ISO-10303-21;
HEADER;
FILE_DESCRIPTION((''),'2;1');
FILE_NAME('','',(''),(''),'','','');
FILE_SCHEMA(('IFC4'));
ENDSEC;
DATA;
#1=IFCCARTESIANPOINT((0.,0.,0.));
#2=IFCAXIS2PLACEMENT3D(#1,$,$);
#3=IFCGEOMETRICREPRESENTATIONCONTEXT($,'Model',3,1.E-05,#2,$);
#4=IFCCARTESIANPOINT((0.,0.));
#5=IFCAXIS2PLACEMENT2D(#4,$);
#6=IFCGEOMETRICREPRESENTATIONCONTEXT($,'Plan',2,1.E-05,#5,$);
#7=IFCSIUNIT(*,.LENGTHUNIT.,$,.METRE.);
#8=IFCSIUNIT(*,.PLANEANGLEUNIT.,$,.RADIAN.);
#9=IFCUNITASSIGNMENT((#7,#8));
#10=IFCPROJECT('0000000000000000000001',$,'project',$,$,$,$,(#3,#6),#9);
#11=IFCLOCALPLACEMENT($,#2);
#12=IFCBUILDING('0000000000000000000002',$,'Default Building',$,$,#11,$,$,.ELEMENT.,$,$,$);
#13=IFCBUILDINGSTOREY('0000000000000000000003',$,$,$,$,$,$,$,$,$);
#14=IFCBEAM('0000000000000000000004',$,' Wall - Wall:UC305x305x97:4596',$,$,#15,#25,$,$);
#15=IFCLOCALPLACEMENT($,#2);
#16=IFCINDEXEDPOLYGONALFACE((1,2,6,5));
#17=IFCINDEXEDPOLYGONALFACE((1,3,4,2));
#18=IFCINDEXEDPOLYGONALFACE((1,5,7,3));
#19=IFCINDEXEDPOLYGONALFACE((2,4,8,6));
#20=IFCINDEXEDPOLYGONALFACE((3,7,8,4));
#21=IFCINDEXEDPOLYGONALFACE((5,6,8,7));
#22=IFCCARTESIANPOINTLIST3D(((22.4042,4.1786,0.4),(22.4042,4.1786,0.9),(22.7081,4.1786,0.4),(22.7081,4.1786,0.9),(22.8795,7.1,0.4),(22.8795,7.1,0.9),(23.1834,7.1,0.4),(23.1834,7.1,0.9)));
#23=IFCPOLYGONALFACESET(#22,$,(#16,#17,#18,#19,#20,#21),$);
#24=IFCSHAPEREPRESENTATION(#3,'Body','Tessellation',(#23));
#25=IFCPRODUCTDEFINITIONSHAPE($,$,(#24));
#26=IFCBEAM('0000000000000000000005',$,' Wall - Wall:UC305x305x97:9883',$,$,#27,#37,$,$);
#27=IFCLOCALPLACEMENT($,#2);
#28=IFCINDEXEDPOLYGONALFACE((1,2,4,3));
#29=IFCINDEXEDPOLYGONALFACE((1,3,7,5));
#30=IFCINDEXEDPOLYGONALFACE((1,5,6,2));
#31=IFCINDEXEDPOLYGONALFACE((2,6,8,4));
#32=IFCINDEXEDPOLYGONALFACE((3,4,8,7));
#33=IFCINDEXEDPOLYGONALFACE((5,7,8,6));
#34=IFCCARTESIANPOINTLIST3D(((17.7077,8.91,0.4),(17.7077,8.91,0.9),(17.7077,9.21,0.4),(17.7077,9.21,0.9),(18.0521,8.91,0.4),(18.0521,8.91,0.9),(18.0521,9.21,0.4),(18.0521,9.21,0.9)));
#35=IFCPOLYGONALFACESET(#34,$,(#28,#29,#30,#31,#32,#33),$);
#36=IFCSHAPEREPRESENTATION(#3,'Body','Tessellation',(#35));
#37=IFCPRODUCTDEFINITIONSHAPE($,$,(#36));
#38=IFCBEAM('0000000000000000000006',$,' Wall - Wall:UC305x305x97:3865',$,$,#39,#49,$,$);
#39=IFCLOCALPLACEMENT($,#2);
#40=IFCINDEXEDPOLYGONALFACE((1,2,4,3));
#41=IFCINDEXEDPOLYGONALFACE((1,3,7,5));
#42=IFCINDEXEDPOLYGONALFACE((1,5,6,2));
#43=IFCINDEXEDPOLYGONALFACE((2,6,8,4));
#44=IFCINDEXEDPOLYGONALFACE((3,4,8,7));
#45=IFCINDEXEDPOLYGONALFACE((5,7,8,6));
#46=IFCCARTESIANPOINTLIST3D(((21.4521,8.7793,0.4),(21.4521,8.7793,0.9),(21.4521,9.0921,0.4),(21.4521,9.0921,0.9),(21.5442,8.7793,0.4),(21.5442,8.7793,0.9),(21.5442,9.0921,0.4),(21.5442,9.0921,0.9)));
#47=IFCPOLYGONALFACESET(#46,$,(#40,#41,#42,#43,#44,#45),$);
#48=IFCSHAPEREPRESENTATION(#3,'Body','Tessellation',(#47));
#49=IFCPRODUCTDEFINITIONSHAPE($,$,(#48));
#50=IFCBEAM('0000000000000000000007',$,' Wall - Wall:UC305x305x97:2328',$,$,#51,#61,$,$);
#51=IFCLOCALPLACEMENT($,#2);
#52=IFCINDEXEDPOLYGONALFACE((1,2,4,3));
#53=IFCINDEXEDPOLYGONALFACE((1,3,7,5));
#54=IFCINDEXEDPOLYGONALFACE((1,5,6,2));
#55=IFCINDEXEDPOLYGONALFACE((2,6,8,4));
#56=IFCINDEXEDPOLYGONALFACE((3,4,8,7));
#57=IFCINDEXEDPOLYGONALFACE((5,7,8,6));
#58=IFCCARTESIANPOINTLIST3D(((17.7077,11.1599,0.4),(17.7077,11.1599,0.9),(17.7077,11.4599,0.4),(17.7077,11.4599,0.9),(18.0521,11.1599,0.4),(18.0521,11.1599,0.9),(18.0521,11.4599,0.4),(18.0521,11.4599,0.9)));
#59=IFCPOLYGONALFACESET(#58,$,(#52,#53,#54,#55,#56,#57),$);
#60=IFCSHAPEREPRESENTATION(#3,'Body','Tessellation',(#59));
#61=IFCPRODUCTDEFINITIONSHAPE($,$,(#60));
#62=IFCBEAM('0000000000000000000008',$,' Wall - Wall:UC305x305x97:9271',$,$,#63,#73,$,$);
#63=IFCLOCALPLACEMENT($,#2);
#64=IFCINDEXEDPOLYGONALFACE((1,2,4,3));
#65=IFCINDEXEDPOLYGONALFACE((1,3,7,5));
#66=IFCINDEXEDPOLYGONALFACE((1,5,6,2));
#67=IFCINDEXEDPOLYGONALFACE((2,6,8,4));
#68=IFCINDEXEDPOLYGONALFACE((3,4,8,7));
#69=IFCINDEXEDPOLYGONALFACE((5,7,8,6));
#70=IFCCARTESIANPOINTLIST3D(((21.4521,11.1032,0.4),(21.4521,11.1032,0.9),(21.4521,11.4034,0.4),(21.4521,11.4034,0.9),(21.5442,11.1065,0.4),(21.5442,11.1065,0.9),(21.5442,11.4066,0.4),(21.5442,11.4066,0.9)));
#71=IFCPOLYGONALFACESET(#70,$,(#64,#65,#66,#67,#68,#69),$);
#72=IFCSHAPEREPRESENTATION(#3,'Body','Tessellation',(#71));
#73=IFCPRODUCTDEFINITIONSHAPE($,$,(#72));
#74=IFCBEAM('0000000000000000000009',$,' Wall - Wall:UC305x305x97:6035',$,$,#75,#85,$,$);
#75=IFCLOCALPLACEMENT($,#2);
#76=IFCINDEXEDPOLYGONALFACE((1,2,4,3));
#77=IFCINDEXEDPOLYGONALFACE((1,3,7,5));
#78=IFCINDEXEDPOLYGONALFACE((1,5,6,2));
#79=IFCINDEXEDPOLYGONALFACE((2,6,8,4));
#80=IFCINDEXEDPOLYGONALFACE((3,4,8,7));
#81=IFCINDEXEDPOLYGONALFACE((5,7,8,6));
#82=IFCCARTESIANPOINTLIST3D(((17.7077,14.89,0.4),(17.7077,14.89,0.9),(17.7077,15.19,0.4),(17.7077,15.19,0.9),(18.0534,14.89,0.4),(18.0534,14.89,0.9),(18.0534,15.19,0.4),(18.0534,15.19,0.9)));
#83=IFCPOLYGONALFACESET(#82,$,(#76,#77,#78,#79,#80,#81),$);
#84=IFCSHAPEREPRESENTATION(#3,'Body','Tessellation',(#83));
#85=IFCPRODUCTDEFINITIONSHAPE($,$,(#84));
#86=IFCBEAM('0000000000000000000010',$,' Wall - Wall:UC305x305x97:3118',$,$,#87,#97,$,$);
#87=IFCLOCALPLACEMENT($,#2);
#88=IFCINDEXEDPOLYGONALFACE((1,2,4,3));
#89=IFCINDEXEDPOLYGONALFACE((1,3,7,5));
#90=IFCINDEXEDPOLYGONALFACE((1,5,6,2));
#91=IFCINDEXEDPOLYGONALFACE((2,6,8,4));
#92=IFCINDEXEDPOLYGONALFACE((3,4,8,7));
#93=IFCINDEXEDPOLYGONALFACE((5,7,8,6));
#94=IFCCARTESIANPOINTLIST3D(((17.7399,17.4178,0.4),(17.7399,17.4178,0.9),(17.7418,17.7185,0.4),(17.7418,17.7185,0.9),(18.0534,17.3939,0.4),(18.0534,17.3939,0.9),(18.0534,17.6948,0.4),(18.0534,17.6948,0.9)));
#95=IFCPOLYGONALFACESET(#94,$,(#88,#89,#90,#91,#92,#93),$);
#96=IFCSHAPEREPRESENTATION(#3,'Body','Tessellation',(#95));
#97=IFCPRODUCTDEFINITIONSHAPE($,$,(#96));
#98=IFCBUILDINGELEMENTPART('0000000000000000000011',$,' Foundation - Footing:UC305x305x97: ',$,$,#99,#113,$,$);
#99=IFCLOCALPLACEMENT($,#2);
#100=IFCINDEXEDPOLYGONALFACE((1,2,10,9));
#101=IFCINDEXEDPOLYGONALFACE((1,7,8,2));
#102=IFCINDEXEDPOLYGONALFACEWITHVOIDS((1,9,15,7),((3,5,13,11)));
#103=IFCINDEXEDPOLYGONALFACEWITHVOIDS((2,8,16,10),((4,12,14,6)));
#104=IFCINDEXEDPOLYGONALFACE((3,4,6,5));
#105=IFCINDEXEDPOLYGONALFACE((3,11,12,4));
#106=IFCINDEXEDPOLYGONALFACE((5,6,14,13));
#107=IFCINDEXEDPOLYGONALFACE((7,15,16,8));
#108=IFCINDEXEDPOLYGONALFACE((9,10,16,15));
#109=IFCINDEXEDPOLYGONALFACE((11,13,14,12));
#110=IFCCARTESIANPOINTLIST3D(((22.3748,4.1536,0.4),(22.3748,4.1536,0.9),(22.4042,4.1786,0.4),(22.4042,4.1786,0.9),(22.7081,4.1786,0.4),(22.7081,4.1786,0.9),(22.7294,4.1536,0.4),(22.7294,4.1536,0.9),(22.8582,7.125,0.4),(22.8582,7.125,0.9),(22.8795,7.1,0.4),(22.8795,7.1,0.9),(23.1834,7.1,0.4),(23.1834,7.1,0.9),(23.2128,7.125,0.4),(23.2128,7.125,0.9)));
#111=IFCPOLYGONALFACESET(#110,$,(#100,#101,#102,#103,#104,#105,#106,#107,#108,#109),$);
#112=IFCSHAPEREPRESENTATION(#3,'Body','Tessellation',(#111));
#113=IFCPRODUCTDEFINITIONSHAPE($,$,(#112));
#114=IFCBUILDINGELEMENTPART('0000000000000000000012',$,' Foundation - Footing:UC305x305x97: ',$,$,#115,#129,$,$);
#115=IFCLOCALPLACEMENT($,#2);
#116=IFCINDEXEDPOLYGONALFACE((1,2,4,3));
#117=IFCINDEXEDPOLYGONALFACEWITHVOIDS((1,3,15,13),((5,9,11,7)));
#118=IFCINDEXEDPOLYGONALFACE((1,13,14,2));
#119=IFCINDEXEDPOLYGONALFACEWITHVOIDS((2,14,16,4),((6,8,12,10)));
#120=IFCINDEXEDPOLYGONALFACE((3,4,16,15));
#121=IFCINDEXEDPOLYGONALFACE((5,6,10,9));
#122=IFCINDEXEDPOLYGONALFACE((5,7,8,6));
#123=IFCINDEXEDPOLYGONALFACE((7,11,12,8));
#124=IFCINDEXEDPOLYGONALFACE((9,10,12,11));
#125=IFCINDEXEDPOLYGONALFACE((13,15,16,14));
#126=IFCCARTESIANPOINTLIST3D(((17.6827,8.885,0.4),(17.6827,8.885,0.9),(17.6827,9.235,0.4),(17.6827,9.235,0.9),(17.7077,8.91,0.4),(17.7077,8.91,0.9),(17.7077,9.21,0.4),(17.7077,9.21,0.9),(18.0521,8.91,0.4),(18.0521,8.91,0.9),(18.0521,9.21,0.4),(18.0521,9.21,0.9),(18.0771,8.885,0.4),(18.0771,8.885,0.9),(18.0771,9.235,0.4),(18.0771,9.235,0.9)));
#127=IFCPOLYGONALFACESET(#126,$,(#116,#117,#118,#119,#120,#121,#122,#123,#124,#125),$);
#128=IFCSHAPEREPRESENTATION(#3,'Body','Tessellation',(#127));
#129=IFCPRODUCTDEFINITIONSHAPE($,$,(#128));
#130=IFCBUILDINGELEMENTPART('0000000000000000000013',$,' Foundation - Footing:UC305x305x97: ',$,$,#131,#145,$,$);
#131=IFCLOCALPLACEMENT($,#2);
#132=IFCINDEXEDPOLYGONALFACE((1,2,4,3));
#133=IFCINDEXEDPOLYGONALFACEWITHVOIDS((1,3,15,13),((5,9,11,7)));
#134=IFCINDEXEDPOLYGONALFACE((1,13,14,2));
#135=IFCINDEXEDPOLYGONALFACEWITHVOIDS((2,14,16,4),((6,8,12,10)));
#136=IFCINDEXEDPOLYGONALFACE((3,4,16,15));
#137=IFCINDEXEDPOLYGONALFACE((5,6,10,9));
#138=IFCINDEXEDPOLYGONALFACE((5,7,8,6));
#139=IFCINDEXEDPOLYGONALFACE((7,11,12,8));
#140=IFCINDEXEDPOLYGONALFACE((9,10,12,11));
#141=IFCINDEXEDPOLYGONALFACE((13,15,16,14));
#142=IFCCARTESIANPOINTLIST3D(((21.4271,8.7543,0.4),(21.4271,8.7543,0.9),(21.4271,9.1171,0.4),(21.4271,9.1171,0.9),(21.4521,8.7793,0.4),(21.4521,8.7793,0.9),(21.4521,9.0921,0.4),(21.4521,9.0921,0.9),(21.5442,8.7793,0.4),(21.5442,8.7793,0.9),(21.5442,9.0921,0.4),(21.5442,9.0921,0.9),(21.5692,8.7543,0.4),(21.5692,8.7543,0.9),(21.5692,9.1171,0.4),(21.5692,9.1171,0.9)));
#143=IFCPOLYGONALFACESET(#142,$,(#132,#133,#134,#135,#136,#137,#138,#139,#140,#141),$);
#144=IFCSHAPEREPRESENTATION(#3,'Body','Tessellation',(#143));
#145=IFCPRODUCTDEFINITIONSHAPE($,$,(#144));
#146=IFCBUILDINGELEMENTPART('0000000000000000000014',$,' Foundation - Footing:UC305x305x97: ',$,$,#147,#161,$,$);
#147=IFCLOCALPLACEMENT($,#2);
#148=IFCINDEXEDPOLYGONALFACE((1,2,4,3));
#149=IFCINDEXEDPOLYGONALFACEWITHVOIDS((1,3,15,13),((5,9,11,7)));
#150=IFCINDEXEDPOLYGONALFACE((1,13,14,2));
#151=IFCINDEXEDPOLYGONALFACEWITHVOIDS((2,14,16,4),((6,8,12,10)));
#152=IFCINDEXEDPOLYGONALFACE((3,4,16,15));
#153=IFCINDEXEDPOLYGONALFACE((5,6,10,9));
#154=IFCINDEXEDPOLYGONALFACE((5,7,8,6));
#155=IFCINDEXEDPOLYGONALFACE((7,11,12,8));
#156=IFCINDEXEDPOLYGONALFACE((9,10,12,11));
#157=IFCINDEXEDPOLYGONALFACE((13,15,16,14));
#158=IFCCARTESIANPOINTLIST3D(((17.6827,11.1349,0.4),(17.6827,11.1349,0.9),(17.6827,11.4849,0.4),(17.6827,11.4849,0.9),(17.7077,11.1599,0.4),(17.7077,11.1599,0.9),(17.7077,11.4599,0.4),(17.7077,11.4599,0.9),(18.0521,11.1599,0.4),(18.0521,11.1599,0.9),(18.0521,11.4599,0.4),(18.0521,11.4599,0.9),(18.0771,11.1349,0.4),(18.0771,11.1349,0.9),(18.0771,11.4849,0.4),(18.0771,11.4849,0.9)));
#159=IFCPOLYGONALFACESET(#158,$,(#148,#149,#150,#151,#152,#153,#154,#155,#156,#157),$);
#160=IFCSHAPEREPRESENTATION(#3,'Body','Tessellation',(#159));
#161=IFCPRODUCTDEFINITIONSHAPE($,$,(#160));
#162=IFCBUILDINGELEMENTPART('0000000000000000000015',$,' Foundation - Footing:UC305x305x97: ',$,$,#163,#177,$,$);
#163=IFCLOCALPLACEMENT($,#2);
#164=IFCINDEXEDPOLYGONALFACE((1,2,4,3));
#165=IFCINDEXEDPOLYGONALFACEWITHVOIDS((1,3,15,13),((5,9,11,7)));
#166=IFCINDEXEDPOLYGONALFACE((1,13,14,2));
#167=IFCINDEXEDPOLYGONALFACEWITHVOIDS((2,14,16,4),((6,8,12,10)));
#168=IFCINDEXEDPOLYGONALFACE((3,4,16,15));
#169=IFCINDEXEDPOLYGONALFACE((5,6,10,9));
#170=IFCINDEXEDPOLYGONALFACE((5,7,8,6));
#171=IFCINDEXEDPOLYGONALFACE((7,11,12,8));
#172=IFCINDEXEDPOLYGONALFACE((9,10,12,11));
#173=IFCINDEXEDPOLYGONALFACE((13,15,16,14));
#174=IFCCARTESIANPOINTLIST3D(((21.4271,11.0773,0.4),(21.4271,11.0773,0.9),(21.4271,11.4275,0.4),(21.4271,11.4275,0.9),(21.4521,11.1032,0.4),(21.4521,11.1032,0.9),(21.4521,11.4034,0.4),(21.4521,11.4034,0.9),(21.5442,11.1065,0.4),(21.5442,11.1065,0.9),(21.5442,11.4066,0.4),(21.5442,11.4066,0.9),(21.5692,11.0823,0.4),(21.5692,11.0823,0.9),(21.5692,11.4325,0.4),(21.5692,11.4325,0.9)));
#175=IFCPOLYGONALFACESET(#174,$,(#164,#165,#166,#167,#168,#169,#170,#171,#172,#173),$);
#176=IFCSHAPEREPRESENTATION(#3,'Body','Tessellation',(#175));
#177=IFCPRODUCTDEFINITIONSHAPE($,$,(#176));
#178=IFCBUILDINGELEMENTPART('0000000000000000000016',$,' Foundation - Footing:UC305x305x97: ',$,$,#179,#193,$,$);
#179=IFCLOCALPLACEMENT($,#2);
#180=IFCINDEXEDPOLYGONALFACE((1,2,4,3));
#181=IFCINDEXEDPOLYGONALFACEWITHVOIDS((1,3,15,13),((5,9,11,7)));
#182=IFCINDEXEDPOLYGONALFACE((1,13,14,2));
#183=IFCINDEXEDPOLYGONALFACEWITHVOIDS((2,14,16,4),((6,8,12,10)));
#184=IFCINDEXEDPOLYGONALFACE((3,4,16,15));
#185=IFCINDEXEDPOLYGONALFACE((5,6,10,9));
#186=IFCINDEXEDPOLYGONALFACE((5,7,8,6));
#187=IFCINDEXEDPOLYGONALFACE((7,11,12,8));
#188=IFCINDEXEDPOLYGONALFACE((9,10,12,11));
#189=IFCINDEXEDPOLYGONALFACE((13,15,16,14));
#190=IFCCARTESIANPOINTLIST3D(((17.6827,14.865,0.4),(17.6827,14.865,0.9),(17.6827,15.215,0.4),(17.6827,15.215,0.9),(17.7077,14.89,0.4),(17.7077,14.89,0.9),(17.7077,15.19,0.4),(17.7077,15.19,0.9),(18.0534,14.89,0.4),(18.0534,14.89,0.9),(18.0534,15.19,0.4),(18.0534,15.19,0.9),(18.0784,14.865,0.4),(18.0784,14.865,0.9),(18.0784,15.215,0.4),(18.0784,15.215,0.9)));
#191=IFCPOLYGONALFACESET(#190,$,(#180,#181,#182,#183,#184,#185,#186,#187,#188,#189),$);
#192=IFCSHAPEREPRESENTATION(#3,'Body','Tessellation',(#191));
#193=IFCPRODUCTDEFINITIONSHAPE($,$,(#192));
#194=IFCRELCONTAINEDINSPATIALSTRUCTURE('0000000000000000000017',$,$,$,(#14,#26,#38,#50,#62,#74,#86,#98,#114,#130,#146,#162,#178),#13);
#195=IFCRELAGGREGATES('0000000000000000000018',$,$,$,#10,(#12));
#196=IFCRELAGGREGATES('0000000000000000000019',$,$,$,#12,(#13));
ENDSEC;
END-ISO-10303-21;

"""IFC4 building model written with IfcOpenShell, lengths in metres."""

from ifc_helpers import new_model, si_unit, origin, origin_2d, place, context, project, spatial, polyline, outline, extrude, element, save


model = new_model("IFC4")

# Units and contexts
model_context = context("Model", 3, precision=1e-05, world=origin())
plan_context = context("Plan", 2, precision=1e-05, world=origin_2d())
ifc_project = project(units=[si_unit("LENGTHUNIT", "METRE"), si_unit("PLANEANGLEUNIT", "RADIAN")], contexts=[model_context, plan_context])

# Building, storey
building_placement = place(None, origin())
building = spatial("IfcBuilding", under=ifc_project, at=building_placement, Name="Default Building", CompositionType="ELEMENT")
storey = spatial("IfcBuildingStorey", under=building)

# Beams
element("IfcBeam", 1, inside=storey, Name=" Wall - Wall:UC305x305x97:4596", context=model_context, shape_type="SweptSolid", body=[
    extrude(outline(polyline([(22.4042, 4.1786, 0.4), (22.7081, 4.1786, 0.4), (23.1834, 7.1, 0.4), (22.8795, 7.1, 0.4), (22.4042, 4.1786, 0.4)])), None, (0.0, 0.0, 1.0), 0.5),
])
element("IfcBeam", 2, inside=storey, Name=" Wall - Wall:UC305x305x97:9883", context=model_context, shape_type="SweptSolid", body=[
    extrude(outline(polyline([(17.7077, 8.91, 0.4), (17.7077, 9.21, 0.4), (18.0521, 9.21, 0.4), (18.0521, 8.91, 0.4), (17.7077, 8.91, 0.4)])), None, (0.0, 0.0, 1.0), 0.5),
])
element("IfcBeam", 3, inside=storey, Name=" Wall - Wall:UC305x305x97:3865", context=model_context, shape_type="SweptSolid", body=[
    extrude(outline(polyline([(21.4521, 8.7793, 0.4), (21.5442, 8.7793, 0.4), (21.5442, 9.0921, 0.4), (21.4521, 9.0921, 0.4), (21.4521, 8.7793, 0.4)])), None, (0.0, 0.0, 1.0), 0.5),
])
element("IfcBeam", 4, inside=storey, Name=" Wall - Wall:UC305x305x97:2328", context=model_context, shape_type="SweptSolid", body=[
    extrude(outline(polyline([(17.7077, 11.1599, 0.4), (18.0521, 11.1599, 0.4), (18.0521, 11.4599, 0.4), (17.7077, 11.4599, 0.4), (17.7077, 11.1599, 0.4)])), None, (0.0, 0.0, 1.0), 0.5),
])
element("IfcBeam", 5, inside=storey, Name=" Wall - Wall:UC305x305x97:9271", context=model_context, shape_type="SweptSolid", body=[
    extrude(outline(polyline([(21.4521, 11.1032, 0.4), (21.5442, 11.1065, 0.4), (21.5442, 11.4066, 0.4), (21.4521, 11.4034, 0.4), (21.4521, 11.1032, 0.4)])), None, (0.0, 0.0, 1.0), 0.5),
])
element("IfcBeam", 6, inside=storey, Name=" Wall - Wall:UC305x305x97:6035", context=model_context, shape_type="SweptSolid", body=[
    extrude(outline(polyline([(17.7077, 15.19, 0.4), (18.0534, 15.19, 0.4), (18.0534, 14.89, 0.4), (17.7077, 14.89, 0.4), (17.7077, 15.19, 0.4)])), None, (0.0, 0.0, 1.0), 0.5),
])
element("IfcBeam", 7, inside=storey, Name=" Wall - Wall:UC305x305x97:3118", context=model_context, shape_type="SweptSolid", body=[
    extrude(outline(polyline([(17.7399, 17.4178, 0.4), (18.0534, 17.3939, 0.4), (18.0534, 17.6948, 0.4), (17.7418, 17.7185, 0.4), (17.7399, 17.4178, 0.4)])), None, (0.0, 0.0, 1.0), 0.5),
])

# Building element parts, openings
building_element_part_1 = element("IfcBuildingElementPart", 8, inside=storey, Name=" Foundation - Footing:UC305x305x97: ", context=model_context, shape_type="SweptSolid", body=[
    extrude(outline(polyline([(22.3748, 4.1536, 0.4), (22.7294, 4.1536, 0.4), (23.2128, 7.125, 0.4), (22.8582, 7.125, 0.4), (22.3748, 4.1536, 0.4)])), None, (0.0, 0.0, 1.0), 0.5),
])
element("IfcOpeningElement", 9, inside=storey, cuts=building_element_part_1, context=model_context, shape_type="SweptSolid", body=[
    extrude(outline(polyline([(22.4042, 4.1786, 0.4), (22.7081, 4.1786, 0.4), (23.1834, 7.1, 0.4), (22.8795, 7.1, 0.4), (22.4042, 4.1786, 0.4)])), None, (0.0, 0.0, 1.0), 0.5),
])
building_element_part_2 = element("IfcBuildingElementPart", 10, inside=storey, Name=" Foundation - Footing:UC305x305x97: ", context=model_context, shape_type="SweptSolid", body=[
    extrude(outline(polyline([(17.6827, 8.885, 0.4), (17.6827, 9.235, 0.4), (18.0771, 9.235, 0.4), (18.0771, 8.885, 0.4), (17.6827, 8.885, 0.4)])), None, (0.0, 0.0, 1.0), 0.5),
])
element("IfcOpeningElement", 11, inside=storey, cuts=building_element_part_2, context=model_context, shape_type="SweptSolid", body=[
    extrude(outline(polyline([(17.7077, 8.91, 0.4), (17.7077, 9.21, 0.4), (18.0521, 9.21, 0.4), (18.0521, 8.91, 0.4), (17.7077, 8.91, 0.4)])), None, (0.0, 0.0, 1.0), 0.5),
])
building_element_part_3 = element("IfcBuildingElementPart", 12, inside=storey, Name=" Foundation - Footing:UC305x305x97: ", context=model_context, shape_type="SweptSolid", body=[
    extrude(outline(polyline([(21.4271, 8.7543, 0.4), (21.5692, 8.7543, 0.4), (21.5692, 9.1171, 0.4), (21.4271, 9.1171, 0.4), (21.4271, 8.7543, 0.4)])), None, (0.0, 0.0, 1.0), 0.5),
])
element("IfcOpeningElement", 13, inside=storey, cuts=building_element_part_3, context=model_context, shape_type="SweptSolid", body=[
    extrude(outline(polyline([(21.4521, 8.7793, 0.4), (21.5442, 8.7793, 0.4), (21.5442, 9.0921, 0.4), (21.4521, 9.0921, 0.4), (21.4521, 8.7793, 0.4)])), None, (0.0, 0.0, 1.0), 0.5),
])
building_element_part_4 = element("IfcBuildingElementPart", 14, inside=storey, Name=" Foundation - Footing:UC305x305x97: ", context=model_context, shape_type="SweptSolid", body=[
    extrude(outline(polyline([(17.6827, 11.1349, 0.4), (18.0771, 11.1349, 0.4), (18.0771, 11.4849, 0.4), (17.6827, 11.4849, 0.4), (17.6827, 11.1349, 0.4)])), None, (0.0, 0.0, 1.0), 0.5),
])
element("IfcOpeningElement", 15, inside=storey, cuts=building_element_part_4, context=model_context, shape_type="SweptSolid", body=[
    extrude(outline(polyline([(17.7077, 11.1599, 0.4), (18.0521, 11.1599, 0.4), (18.0521, 11.4599, 0.4), (17.7077, 11.4599, 0.4), (17.7077, 11.1599, 0.4)])), None, (0.0, 0.0, 1.0), 0.5),
])
building_element_part_5 = element("IfcBuildingElementPart", 16, inside=storey, Name=" Foundation - Footing:UC305x305x97: ", context=model_context, shape_type="SweptSolid", body=[
    extrude(outline(polyline([(21.4271, 11.0773, 0.4), (21.5692, 11.0823, 0.4), (21.5692, 11.4325, 0.4), (21.4271, 11.4275, 0.4), (21.4271, 11.0773, 0.4)])), None, (0.0, 0.0, 1.0), 0.5),
])
element("IfcOpeningElement", 17, inside=storey, cuts=building_element_part_5, context=model_context, shape_type="SweptSolid", body=[
    extrude(outline(polyline([(21.4521, 11.1032, 0.4), (21.5442, 11.1065, 0.4), (21.5442, 11.4066, 0.4), (21.4521, 11.4034, 0.4), (21.4521, 11.1032, 0.4)])), None, (0.0, 0.0, 1.0), 0.5),
])
building_element_part_6 = element("IfcBuildingElementPart", 18, inside=storey, Name=" Foundation - Footing:UC305x305x97: ", context=model_context, shape_type="SweptSolid", body=[
    extrude(outline(polyline([(17.6827, 15.215, 0.4), (18.0784, 15.215, 0.4), (18.0784, 14.865, 0.4), (17.6827, 14.865, 0.4), (17.6827, 15.215, 0.4)])), None, (0.0, 0.0, 1.0), 0.5),
])
element("IfcOpeningElement", 19, inside=storey, cuts=building_element_part_6, context=model_context, shape_type="SweptSolid", body=[
    extrude(outline(polyline([(17.7077, 15.19, 0.4), (18.0534, 15.19, 0.4), (18.0534, 14.89, 0.4), (17.7077, 14.89, 0.4), (17.7077, 15.19, 0.4)])), None, (0.0, 0.0, 1.0), 0.5),
])

save(model, "model.ifc")
